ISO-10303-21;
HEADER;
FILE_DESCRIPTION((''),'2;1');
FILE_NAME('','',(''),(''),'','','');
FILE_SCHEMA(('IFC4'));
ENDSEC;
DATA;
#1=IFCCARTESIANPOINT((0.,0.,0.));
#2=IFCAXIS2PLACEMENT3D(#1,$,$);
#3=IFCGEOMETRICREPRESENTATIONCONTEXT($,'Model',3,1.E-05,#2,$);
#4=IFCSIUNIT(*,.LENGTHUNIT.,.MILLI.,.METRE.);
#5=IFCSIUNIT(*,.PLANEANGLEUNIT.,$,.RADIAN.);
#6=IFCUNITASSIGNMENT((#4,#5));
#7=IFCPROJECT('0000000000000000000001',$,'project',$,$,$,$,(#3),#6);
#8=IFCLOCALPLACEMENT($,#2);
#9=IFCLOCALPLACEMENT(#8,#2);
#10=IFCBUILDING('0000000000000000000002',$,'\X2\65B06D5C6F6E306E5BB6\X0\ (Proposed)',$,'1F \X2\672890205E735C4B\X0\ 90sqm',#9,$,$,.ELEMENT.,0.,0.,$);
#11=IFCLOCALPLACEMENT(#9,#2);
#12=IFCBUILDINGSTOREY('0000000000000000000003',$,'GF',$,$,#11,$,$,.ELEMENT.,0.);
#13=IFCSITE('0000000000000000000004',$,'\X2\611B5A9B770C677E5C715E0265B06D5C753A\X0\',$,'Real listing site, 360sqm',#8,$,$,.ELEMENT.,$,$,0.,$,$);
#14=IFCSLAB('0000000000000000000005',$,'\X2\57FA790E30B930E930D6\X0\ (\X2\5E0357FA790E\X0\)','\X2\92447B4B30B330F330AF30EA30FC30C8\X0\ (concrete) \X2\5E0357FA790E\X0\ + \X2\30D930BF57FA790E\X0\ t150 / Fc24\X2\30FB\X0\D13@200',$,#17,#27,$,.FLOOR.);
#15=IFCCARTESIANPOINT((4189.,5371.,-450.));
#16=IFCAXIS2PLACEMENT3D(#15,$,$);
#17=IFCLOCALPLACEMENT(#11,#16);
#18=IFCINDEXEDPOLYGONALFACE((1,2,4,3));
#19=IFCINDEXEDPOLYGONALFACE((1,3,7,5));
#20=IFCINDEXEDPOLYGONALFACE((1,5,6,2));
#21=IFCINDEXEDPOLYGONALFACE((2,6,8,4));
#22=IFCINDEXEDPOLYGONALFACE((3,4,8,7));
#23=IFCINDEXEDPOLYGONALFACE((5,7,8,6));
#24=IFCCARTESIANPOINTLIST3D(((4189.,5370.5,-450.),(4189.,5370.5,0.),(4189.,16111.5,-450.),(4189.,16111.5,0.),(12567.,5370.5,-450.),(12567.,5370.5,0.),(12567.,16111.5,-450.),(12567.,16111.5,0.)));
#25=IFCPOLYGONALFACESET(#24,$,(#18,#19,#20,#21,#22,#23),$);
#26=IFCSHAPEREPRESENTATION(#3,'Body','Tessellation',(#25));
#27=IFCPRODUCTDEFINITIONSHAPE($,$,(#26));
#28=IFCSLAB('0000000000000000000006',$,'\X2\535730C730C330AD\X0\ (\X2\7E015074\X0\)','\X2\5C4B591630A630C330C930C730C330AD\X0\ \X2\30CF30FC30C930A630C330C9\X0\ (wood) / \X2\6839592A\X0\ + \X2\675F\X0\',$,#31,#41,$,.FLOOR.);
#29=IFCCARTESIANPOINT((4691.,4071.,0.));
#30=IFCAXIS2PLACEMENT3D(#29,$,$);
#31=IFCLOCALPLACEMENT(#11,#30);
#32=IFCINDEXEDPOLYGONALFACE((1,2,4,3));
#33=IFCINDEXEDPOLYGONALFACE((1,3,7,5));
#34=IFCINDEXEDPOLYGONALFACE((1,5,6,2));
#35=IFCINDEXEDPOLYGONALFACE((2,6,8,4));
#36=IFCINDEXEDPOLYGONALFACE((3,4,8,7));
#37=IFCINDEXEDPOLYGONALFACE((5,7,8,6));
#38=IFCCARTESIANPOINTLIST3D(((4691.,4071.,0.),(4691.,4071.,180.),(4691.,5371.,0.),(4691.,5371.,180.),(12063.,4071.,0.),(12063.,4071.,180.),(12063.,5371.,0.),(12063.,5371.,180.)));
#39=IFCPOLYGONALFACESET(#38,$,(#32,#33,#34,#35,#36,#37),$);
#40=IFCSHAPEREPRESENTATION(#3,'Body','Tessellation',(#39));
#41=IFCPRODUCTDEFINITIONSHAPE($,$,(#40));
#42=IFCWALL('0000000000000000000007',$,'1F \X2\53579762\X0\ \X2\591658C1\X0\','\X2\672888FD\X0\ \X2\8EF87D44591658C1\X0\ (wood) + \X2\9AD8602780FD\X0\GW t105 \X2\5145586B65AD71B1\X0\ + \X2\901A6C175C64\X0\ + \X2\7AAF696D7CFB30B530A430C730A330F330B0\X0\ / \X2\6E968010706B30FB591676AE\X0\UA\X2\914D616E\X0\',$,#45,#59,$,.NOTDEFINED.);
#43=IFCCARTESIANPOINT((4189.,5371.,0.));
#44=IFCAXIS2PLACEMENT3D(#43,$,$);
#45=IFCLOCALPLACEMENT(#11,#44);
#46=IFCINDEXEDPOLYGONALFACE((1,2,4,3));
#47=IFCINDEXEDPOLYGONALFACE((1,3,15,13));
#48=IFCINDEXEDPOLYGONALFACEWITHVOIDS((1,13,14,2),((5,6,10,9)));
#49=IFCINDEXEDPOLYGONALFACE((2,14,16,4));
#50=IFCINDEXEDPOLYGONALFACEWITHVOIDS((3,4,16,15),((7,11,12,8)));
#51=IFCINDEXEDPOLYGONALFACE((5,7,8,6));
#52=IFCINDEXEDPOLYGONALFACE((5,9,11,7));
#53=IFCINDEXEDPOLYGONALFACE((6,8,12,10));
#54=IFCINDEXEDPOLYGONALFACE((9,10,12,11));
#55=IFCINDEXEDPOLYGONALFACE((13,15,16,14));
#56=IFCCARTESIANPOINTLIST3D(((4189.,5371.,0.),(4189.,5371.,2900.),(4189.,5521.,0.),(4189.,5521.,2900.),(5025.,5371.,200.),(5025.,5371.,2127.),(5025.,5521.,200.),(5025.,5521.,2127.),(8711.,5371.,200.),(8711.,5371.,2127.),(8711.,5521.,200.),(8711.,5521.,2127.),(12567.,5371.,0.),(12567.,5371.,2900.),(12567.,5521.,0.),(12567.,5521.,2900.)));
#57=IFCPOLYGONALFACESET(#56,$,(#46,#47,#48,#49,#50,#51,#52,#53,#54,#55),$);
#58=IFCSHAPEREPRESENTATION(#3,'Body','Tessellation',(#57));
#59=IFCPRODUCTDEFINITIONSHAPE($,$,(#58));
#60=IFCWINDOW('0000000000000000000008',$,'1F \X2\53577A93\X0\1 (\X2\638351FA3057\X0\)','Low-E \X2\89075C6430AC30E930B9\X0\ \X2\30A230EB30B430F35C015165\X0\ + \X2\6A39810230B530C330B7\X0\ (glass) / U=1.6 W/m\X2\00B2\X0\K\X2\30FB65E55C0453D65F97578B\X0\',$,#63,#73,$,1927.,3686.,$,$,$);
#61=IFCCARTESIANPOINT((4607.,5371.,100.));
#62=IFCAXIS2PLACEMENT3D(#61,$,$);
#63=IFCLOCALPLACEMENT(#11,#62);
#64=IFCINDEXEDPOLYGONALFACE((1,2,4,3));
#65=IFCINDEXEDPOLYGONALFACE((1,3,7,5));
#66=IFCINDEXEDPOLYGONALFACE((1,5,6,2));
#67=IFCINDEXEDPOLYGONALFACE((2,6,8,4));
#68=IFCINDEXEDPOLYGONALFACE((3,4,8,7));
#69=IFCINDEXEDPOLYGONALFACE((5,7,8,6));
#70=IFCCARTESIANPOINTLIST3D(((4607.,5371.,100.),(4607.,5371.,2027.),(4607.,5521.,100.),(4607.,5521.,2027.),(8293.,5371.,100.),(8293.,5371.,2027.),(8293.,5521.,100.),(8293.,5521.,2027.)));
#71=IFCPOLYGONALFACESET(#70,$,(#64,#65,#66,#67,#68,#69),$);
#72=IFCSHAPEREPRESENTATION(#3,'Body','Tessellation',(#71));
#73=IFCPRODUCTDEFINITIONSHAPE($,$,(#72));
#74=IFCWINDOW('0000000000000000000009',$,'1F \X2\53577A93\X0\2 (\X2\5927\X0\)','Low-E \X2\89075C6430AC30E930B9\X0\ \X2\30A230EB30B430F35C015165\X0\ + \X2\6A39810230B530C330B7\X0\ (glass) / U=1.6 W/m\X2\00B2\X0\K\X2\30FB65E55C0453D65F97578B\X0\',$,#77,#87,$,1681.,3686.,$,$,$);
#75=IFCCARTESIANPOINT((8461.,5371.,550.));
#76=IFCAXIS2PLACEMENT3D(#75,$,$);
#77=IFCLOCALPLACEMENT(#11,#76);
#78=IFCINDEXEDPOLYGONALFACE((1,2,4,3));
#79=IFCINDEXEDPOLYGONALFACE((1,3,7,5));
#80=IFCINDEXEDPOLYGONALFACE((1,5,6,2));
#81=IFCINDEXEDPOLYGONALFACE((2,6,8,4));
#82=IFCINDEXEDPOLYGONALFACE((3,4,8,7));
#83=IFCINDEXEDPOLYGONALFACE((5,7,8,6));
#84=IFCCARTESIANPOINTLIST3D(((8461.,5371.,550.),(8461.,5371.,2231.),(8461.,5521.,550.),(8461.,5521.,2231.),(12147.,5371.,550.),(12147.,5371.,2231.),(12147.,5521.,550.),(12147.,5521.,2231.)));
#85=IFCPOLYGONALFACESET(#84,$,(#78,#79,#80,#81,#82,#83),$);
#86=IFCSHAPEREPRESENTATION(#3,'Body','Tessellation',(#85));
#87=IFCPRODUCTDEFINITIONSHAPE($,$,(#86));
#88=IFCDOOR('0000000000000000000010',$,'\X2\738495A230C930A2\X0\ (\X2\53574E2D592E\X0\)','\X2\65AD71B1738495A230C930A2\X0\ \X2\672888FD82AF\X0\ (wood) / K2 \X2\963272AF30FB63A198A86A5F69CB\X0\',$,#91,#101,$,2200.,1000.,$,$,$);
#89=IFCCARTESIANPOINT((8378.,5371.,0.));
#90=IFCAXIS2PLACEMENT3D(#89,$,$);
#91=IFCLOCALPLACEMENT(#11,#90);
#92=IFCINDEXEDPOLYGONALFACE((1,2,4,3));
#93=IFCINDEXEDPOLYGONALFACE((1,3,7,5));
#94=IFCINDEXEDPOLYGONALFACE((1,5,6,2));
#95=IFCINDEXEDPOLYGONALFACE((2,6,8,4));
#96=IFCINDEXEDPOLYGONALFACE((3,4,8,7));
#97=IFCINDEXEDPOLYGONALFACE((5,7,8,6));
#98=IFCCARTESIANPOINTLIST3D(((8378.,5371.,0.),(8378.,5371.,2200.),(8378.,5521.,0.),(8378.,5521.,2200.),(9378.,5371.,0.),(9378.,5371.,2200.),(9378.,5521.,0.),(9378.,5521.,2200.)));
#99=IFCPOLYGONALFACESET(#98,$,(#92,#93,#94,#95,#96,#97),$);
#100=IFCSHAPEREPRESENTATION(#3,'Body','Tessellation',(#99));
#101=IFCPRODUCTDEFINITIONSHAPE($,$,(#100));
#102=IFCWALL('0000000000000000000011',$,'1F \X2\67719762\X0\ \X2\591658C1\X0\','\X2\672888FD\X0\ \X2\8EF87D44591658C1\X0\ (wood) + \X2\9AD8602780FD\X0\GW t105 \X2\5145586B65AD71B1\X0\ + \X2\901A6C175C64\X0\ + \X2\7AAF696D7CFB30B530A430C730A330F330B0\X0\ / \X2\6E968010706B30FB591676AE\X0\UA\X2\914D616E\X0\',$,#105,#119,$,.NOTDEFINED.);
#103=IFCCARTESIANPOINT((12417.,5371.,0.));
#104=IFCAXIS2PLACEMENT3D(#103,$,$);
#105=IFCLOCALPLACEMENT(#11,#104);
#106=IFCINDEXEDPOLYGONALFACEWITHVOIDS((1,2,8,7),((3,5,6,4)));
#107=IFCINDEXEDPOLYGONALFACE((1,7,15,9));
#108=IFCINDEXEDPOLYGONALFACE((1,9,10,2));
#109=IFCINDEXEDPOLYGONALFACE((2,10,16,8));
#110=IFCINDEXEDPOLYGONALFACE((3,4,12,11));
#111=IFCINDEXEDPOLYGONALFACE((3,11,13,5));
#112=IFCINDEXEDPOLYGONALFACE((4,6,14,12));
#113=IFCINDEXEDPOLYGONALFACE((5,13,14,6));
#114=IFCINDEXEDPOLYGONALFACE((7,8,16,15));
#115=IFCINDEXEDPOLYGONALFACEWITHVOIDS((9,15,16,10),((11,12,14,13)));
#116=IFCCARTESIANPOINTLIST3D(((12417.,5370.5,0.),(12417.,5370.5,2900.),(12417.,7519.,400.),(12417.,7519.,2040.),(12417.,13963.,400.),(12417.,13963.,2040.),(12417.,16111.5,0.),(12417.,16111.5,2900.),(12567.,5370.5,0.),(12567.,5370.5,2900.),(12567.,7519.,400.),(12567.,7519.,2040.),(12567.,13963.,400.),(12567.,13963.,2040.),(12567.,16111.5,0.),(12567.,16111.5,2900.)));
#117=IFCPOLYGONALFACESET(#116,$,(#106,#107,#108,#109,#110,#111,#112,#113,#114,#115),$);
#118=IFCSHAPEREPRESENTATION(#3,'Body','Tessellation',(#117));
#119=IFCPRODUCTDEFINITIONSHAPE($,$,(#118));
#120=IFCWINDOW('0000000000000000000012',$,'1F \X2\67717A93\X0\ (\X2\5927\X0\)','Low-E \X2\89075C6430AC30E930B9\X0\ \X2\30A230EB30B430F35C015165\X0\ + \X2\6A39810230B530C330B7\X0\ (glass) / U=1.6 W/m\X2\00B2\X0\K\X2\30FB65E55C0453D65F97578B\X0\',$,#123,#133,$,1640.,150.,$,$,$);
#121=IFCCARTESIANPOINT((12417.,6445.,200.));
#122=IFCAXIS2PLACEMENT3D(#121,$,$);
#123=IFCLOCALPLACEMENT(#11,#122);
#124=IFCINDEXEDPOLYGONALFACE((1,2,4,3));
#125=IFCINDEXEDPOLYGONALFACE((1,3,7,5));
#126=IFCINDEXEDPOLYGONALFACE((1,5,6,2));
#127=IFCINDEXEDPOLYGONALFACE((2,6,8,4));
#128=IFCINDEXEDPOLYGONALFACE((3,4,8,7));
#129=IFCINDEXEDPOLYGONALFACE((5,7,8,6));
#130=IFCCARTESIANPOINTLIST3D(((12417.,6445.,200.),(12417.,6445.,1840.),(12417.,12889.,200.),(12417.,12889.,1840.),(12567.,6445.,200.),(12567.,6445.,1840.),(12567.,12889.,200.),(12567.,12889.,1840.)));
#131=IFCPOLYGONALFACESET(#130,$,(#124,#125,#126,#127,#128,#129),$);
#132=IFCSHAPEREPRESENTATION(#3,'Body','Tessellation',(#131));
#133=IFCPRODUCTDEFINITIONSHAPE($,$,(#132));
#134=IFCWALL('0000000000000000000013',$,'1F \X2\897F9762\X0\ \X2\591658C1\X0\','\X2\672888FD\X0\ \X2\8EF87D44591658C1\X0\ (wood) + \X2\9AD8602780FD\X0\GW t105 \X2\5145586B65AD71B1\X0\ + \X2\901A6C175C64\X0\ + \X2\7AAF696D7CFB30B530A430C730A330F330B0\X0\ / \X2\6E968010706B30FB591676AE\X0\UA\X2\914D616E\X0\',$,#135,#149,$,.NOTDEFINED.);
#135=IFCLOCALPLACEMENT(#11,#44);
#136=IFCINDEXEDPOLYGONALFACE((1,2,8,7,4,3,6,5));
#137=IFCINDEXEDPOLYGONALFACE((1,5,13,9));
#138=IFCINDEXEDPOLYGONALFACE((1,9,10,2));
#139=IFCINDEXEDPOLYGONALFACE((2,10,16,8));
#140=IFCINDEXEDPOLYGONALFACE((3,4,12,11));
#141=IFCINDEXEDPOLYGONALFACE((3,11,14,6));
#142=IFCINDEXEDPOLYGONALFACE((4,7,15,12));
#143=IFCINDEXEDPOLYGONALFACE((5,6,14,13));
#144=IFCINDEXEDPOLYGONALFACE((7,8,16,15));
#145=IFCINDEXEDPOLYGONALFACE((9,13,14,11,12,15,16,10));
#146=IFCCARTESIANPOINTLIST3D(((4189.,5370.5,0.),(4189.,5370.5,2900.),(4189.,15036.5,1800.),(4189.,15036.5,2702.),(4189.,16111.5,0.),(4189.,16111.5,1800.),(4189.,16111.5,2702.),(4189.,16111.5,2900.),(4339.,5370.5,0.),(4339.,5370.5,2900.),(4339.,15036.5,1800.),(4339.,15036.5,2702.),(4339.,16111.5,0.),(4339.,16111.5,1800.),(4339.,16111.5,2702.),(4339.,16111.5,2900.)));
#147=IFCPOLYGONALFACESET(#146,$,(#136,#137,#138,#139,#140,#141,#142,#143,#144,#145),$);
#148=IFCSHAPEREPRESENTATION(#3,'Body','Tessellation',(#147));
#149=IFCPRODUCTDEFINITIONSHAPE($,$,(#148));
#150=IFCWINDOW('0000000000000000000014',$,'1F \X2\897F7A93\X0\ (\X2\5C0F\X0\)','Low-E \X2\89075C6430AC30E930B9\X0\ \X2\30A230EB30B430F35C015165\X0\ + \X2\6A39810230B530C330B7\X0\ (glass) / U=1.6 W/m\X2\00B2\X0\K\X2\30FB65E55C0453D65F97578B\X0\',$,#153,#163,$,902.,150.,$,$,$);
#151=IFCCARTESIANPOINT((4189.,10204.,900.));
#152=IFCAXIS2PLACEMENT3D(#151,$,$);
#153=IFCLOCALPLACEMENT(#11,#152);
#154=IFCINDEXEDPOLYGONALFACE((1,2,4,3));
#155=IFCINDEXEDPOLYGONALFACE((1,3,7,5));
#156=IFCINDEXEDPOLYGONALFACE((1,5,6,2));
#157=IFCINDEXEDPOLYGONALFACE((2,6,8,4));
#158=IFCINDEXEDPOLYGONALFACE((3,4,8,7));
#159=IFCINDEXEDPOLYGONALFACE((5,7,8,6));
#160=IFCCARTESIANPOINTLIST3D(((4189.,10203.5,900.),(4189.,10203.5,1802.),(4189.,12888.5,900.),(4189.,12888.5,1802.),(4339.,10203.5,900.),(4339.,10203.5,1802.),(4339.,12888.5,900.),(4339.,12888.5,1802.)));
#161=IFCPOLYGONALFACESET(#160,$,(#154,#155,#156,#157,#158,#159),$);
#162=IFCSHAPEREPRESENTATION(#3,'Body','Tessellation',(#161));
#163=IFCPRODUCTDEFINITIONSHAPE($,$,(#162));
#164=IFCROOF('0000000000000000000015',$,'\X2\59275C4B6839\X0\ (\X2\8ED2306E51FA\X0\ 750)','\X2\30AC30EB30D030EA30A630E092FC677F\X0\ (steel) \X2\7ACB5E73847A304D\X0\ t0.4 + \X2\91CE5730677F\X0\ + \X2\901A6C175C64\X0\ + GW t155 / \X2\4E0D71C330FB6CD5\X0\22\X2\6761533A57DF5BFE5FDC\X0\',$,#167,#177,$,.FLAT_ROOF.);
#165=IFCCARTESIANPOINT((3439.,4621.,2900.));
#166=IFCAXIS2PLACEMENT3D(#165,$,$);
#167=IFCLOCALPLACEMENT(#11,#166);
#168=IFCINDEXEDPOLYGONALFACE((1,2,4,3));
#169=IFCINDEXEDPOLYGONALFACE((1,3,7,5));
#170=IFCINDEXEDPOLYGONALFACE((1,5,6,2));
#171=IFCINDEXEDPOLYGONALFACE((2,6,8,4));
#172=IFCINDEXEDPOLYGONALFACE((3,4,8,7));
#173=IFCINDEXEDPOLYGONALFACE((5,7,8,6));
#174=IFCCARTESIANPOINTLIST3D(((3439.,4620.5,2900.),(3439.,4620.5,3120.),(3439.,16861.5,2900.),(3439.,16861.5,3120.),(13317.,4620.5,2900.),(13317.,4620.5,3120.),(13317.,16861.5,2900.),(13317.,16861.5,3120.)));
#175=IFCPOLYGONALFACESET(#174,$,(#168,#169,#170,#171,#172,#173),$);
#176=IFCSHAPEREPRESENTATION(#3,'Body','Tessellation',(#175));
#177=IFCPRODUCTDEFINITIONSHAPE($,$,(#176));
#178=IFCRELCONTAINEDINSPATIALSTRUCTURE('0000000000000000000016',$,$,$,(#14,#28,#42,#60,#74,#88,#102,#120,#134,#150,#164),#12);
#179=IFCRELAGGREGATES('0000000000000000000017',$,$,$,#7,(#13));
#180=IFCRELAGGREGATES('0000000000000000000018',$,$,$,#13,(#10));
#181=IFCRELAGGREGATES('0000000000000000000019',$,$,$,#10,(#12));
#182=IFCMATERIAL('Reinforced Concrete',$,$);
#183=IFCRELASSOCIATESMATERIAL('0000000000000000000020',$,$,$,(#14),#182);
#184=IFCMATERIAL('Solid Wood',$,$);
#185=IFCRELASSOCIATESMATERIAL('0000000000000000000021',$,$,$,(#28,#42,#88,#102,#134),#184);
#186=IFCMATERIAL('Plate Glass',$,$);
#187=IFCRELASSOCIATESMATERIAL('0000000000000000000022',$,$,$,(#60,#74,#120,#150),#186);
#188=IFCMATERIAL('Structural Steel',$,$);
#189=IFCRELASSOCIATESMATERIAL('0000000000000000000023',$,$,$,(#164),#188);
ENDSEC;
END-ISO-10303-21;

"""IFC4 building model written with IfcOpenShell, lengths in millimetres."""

from ifc_helpers import new_model, si_unit, frame, frame_2d, origin, place, context, project, spatial, rectangle, extrude, material, element, fill, save


model = new_model("IFC4")

# Units and contexts
model_context = context("Model", 3, precision=1e-05, world=origin())
ifc_project = project(units=[si_unit("LENGTHUNIT", "METRE", prefix="MILLI"), si_unit("PLANEANGLEUNIT", "RADIAN")], contexts=[model_context])

# Site, building, storey
site_placement = place(None, origin())
site = spatial("IfcSite", under=ifc_project, at=site_placement, Name="愛媛県松山市新浜町", ObjectType="Real listing site, 360sqm", CompositionType="ELEMENT", RefElevation=0.0)
building_placement = place(site_placement, origin())
building = spatial("IfcBuilding", under=site, at=building_placement, Name="新浜潮の家 (Proposed)", ObjectType="1F 木造平屋 90sqm", CompositionType="ELEMENT", ElevationOfRefHeight=0.0, ElevationOfTerrain=0.0)
storey_placement = place(building_placement, origin())
storey = spatial("IfcBuildingStorey", under=building, at=storey_placement, Name="GF", CompositionType="ELEMENT", Elevation=0.0)

# Slabs
ifc_material_1 = material(Name="Reinforced Concrete")
slab_1_placement = place(storey_placement, frame((4189.0, 5371.0, -450.0)))
element("IfcSlab", 1, at=slab_1_placement, inside=storey, material=ifc_material_1, Name="基礎スラブ (布基礎)", Description="鉄筋コンクリート (concrete) 布基礎 + ベタ基礎 t150 / Fc24・D13@200", PredefinedType="FLOOR", context=model_context, shape_type="SweptSolid", body=[
    extrude(rectangle(XDim=8378.0, YDim=10741.0, at=frame_2d((4189.0, 5370.0))), frame((4189.0, 5371.0, -450.0)), (0.0, 0.0, 1.0), 450.0),
])
ifc_material_2 = material(Name="Solid Wood")
slab_2_placement = place(storey_placement, frame((4691.0, 4071.0, 0.0)))
element("IfcSlab", 2, at=slab_2_placement, inside=storey, material=ifc_material_2, Name="南デッキ (縁側)", Description="屋外ウッドデッキ ハードウッド (wood) / 根太 + 束", PredefinedType="FLOOR", context=model_context, shape_type="SweptSolid", body=[
    extrude(rectangle(XDim=7372.0, YDim=1300.0, at=frame_2d((3686.0, 650.0))), frame((4691.0, 4071.0, 0.0)), (0.0, 0.0, 1.0), 180.0),
])

# Wall, openings, windows, door
wall_1_placement = place(storey_placement, frame((4189.0, 5371.0, 0.0)))
wall_1 = element("IfcWall", 3, at=wall_1_placement, inside=storey, material=ifc_material_2, Name="1F 南面 外壁", Description="木製 軸組外壁 (wood) + 高性能GW t105 充填断熱 + 通気層 + 窯業系サイディング / 準耐火・外皮UA配慮", PredefinedType="NOTDEFINED", context=model_context, shape_type="SweptSolid", body=[
    extrude(rectangle(XDim=8378.0, YDim=150.0, at=frame_2d((4189.0, 75.0))), frame((4189.0, 5371.0, 0.0)), (0.0, 0.0, 1.0), 2900.0),
])
opening_1_placement = place(storey_placement, frame((4607.0, 5371.0, 100.0)))
opening_1 = element("IfcOpeningElement", 4, at=opening_1_placement, cuts=wall_1, PredefinedType="NOTDEFINED", context=model_context, shape_type="SweptSolid", body=[
    extrude(rectangle(XDim=3686.0, YDim=150.0, at=frame_2d((1843.0, 75.0))), frame((4607.0, 5371.0, 100.0)), (0.0, 0.0, 1.0), 1927.0),
])
opening_2_placement = place(storey_placement, frame((8461.0, 5371.0, 550.0)))
opening_2 = element("IfcOpeningElement", 5, at=opening_2_placement, cuts=wall_1, PredefinedType="NOTDEFINED", context=model_context, shape_type="SweptSolid", body=[
    extrude(rectangle(XDim=3686.0, YDim=150.0, at=frame_2d((1843.0, 75.0))), frame((8461.0, 5371.0, 550.0)), (0.0, 0.0, 1.0), 1681.0),
])
opening_3_placement = place(storey_placement, frame((8378.0, 5371.0, 0.0)))
opening_3 = element("IfcOpeningElement", 6, at=opening_3_placement, cuts=wall_1, PredefinedType="NOTDEFINED", context=model_context, shape_type="SweptSolid", body=[
    extrude(rectangle(XDim=1000.0, YDim=150.0, at=frame_2d((500.0, 75.0))), frame((8378.0, 5371.0, 0.0)), (0.0, 0.0, 1.0), 2200.0),
])
ifc_material_3 = material(Name="Plate Glass")
window_1_placement = place(storey_placement, frame((4607.0, 5371.0, 100.0)))
window_1 = element("IfcWindow", 7, at=window_1_placement, inside=storey, material=ifc_material_3, Name="1F 南窓1 (掃出し)", Description="Low-E 複層ガラス アルゴン封入 + 樹脂サッシ (glass) / U=1.6 W/m²K・日射取得型", OverallHeight=1927.0, OverallWidth=3686.0, context=model_context, shape_type="SweptSolid", body=[
    extrude(rectangle(XDim=3686.0, YDim=150.0, at=frame_2d((1843.0, 75.0))), frame((4607.0, 5371.0, 100.0)), (0.0, 0.0, 1.0), 1927.0),
])
fill(opening_1, window_1)
window_2_placement = place(storey_placement, frame((8461.0, 5371.0, 550.0)))
window_2 = element("IfcWindow", 8, at=window_2_placement, inside=storey, material=ifc_material_3, Name="1F 南窓2 (大)", Description="Low-E 複層ガラス アルゴン封入 + 樹脂サッシ (glass) / U=1.6 W/m²K・日射取得型", OverallHeight=1681.0, OverallWidth=3686.0, context=model_context, shape_type="SweptSolid", body=[
    extrude(rectangle(XDim=3686.0, YDim=150.0, at=frame_2d((1843.0, 75.0))), frame((8461.0, 5371.0, 550.0)), (0.0, 0.0, 1.0), 1681.0),
])
fill(opening_2, window_2)
door_placement = place(storey_placement, frame((8378.0, 5371.0, 0.0)))
door = element("IfcDoor", 9, at=door_placement, inside=storey, material=ifc_material_2, Name="玄関ドア (南中央)", Description="断熱玄関ドア 木製芯 (wood) / K2 防犯・採風機構", OverallHeight=2200.0, OverallWidth=1000.0, context=model_context, shape_type="SweptSolid", body=[
    extrude(rectangle(XDim=1000.0, YDim=150.0, at=frame_2d((500.0, 75.0))), frame((8378.0, 5371.0, 0.0)), (0.0, 0.0, 1.0), 2200.0),
])
fill(opening_3, door)

# Walls, openings, windows
wall_2_placement = place(storey_placement, frame((12417.0, 5371.0, 0.0)))
wall_2 = element("IfcWall", 10, at=wall_2_placement, inside=storey, material=ifc_material_2, Name="1F 東面 外壁", Description="木製 軸組外壁 (wood) + 高性能GW t105 充填断熱 + 通気層 + 窯業系サイディング / 準耐火・外皮UA配慮", PredefinedType="NOTDEFINED", context=model_context, shape_type="SweptSolid", body=[
    extrude(rectangle(XDim=150.0, YDim=10741.0, at=frame_2d((75.0, 5370.0))), frame((12417.0, 5371.0, 0.0)), (0.0, 0.0, 1.0), 2900.0),
])
opening_4_placement = place(storey_placement, frame((12417.0, 6445.0, 200.0)))
opening_4 = element("IfcOpeningElement", 11, at=opening_4_placement, cuts=wall_2, PredefinedType="NOTDEFINED", context=model_context, shape_type="SweptSolid", body=[
    extrude(rectangle(XDim=150.0, YDim=6444.0, at=frame_2d((75.0, 3222.0))), frame((12417.0, 6445.0, 200.0)), (0.0, 0.0, 1.0), 1640.0),
])
window_3_placement = place(storey_placement, frame((12417.0, 6445.0, 200.0)))
window_3 = element("IfcWindow", 12, at=window_3_placement, inside=storey, material=ifc_material_3, Name="1F 東窓 (大)", Description="Low-E 複層ガラス アルゴン封入 + 樹脂サッシ (glass) / U=1.6 W/m²K・日射取得型", OverallHeight=1640.0, OverallWidth=150.0, context=model_context, shape_type="SweptSolid", body=[
    extrude(rectangle(XDim=150.0, YDim=6444.0, at=frame_2d((75.0, 3222.0))), frame((12417.0, 6445.0, 200.0)), (0.0, 0.0, 1.0), 1640.0),
])
fill(opening_4, window_3)
wall_3_placement = place(storey_placement, frame((4189.0, 5371.0, 0.0)))
wall_3 = element("IfcWall", 13, at=wall_3_placement, inside=storey, material=ifc_material_2, Name="1F 西面 外壁", Description="木製 軸組外壁 (wood) + 高性能GW t105 充填断熱 + 通気層 + 窯業系サイディング / 準耐火・外皮UA配慮", PredefinedType="NOTDEFINED", context=model_context, shape_type="SweptSolid", body=[
    extrude(rectangle(XDim=150.0, YDim=10741.0, at=frame_2d((75.0, 5370.0))), frame((4189.0, 5371.0, 0.0)), (0.0, 0.0, 1.0), 2900.0),
])
opening_5_placement = place(storey_placement, frame((4189.0, 10204.0, 900.0)))
opening_5 = element("IfcOpeningElement", 14, at=opening_5_placement, cuts=wall_3, PredefinedType="NOTDEFINED", context=model_context, shape_type="SweptSolid", body=[
    extrude(rectangle(XDim=150.0, YDim=2685.0, at=frame_2d((75.0, 1342.0))), frame((4189.0, 10204.0, 900.0)), (0.0, 0.0, 1.0), 902.0),
])
window_4_placement = place(storey_placement, frame((4189.0, 10204.0, 900.0)))
window_4 = element("IfcWindow", 15, at=window_4_placement, inside=storey, material=ifc_material_3, Name="1F 西窓 (小)", Description="Low-E 複層ガラス アルゴン封入 + 樹脂サッシ (glass) / U=1.6 W/m²K・日射取得型", OverallHeight=902.0, OverallWidth=150.0, context=model_context, shape_type="SweptSolid", body=[
    extrude(rectangle(XDim=150.0, YDim=2685.0, at=frame_2d((75.0, 1342.0))), frame((4189.0, 10204.0, 900.0)), (0.0, 0.0, 1.0), 902.0),
])
fill(opening_5, window_4)

# Roof
ifc_material_4 = material(Name="Structural Steel")
roof_placement = place(storey_placement, frame((3439.0, 4621.0, 2900.0)))
element("IfcRoof", 16, at=roof_placement, inside=storey, material=ifc_material_4, Name="大屋根 (軒の出 750)", Description="ガルバリウム鋼板 (steel) 立平葺き t0.4 + 野地板 + 通気層 + GW t155 / 不燃・法22条区域対応", PredefinedType="FLAT_ROOF", context=model_context, shape_type="SweptSolid", body=[
    extrude(rectangle(XDim=9878.0, YDim=12241.0, at=frame_2d((4939.0, 6120.0))), frame((3439.0, 4621.0, 2900.0)), (0.0, 0.0, 1.0), 220.0),
])

save(model, "model.ifc")
